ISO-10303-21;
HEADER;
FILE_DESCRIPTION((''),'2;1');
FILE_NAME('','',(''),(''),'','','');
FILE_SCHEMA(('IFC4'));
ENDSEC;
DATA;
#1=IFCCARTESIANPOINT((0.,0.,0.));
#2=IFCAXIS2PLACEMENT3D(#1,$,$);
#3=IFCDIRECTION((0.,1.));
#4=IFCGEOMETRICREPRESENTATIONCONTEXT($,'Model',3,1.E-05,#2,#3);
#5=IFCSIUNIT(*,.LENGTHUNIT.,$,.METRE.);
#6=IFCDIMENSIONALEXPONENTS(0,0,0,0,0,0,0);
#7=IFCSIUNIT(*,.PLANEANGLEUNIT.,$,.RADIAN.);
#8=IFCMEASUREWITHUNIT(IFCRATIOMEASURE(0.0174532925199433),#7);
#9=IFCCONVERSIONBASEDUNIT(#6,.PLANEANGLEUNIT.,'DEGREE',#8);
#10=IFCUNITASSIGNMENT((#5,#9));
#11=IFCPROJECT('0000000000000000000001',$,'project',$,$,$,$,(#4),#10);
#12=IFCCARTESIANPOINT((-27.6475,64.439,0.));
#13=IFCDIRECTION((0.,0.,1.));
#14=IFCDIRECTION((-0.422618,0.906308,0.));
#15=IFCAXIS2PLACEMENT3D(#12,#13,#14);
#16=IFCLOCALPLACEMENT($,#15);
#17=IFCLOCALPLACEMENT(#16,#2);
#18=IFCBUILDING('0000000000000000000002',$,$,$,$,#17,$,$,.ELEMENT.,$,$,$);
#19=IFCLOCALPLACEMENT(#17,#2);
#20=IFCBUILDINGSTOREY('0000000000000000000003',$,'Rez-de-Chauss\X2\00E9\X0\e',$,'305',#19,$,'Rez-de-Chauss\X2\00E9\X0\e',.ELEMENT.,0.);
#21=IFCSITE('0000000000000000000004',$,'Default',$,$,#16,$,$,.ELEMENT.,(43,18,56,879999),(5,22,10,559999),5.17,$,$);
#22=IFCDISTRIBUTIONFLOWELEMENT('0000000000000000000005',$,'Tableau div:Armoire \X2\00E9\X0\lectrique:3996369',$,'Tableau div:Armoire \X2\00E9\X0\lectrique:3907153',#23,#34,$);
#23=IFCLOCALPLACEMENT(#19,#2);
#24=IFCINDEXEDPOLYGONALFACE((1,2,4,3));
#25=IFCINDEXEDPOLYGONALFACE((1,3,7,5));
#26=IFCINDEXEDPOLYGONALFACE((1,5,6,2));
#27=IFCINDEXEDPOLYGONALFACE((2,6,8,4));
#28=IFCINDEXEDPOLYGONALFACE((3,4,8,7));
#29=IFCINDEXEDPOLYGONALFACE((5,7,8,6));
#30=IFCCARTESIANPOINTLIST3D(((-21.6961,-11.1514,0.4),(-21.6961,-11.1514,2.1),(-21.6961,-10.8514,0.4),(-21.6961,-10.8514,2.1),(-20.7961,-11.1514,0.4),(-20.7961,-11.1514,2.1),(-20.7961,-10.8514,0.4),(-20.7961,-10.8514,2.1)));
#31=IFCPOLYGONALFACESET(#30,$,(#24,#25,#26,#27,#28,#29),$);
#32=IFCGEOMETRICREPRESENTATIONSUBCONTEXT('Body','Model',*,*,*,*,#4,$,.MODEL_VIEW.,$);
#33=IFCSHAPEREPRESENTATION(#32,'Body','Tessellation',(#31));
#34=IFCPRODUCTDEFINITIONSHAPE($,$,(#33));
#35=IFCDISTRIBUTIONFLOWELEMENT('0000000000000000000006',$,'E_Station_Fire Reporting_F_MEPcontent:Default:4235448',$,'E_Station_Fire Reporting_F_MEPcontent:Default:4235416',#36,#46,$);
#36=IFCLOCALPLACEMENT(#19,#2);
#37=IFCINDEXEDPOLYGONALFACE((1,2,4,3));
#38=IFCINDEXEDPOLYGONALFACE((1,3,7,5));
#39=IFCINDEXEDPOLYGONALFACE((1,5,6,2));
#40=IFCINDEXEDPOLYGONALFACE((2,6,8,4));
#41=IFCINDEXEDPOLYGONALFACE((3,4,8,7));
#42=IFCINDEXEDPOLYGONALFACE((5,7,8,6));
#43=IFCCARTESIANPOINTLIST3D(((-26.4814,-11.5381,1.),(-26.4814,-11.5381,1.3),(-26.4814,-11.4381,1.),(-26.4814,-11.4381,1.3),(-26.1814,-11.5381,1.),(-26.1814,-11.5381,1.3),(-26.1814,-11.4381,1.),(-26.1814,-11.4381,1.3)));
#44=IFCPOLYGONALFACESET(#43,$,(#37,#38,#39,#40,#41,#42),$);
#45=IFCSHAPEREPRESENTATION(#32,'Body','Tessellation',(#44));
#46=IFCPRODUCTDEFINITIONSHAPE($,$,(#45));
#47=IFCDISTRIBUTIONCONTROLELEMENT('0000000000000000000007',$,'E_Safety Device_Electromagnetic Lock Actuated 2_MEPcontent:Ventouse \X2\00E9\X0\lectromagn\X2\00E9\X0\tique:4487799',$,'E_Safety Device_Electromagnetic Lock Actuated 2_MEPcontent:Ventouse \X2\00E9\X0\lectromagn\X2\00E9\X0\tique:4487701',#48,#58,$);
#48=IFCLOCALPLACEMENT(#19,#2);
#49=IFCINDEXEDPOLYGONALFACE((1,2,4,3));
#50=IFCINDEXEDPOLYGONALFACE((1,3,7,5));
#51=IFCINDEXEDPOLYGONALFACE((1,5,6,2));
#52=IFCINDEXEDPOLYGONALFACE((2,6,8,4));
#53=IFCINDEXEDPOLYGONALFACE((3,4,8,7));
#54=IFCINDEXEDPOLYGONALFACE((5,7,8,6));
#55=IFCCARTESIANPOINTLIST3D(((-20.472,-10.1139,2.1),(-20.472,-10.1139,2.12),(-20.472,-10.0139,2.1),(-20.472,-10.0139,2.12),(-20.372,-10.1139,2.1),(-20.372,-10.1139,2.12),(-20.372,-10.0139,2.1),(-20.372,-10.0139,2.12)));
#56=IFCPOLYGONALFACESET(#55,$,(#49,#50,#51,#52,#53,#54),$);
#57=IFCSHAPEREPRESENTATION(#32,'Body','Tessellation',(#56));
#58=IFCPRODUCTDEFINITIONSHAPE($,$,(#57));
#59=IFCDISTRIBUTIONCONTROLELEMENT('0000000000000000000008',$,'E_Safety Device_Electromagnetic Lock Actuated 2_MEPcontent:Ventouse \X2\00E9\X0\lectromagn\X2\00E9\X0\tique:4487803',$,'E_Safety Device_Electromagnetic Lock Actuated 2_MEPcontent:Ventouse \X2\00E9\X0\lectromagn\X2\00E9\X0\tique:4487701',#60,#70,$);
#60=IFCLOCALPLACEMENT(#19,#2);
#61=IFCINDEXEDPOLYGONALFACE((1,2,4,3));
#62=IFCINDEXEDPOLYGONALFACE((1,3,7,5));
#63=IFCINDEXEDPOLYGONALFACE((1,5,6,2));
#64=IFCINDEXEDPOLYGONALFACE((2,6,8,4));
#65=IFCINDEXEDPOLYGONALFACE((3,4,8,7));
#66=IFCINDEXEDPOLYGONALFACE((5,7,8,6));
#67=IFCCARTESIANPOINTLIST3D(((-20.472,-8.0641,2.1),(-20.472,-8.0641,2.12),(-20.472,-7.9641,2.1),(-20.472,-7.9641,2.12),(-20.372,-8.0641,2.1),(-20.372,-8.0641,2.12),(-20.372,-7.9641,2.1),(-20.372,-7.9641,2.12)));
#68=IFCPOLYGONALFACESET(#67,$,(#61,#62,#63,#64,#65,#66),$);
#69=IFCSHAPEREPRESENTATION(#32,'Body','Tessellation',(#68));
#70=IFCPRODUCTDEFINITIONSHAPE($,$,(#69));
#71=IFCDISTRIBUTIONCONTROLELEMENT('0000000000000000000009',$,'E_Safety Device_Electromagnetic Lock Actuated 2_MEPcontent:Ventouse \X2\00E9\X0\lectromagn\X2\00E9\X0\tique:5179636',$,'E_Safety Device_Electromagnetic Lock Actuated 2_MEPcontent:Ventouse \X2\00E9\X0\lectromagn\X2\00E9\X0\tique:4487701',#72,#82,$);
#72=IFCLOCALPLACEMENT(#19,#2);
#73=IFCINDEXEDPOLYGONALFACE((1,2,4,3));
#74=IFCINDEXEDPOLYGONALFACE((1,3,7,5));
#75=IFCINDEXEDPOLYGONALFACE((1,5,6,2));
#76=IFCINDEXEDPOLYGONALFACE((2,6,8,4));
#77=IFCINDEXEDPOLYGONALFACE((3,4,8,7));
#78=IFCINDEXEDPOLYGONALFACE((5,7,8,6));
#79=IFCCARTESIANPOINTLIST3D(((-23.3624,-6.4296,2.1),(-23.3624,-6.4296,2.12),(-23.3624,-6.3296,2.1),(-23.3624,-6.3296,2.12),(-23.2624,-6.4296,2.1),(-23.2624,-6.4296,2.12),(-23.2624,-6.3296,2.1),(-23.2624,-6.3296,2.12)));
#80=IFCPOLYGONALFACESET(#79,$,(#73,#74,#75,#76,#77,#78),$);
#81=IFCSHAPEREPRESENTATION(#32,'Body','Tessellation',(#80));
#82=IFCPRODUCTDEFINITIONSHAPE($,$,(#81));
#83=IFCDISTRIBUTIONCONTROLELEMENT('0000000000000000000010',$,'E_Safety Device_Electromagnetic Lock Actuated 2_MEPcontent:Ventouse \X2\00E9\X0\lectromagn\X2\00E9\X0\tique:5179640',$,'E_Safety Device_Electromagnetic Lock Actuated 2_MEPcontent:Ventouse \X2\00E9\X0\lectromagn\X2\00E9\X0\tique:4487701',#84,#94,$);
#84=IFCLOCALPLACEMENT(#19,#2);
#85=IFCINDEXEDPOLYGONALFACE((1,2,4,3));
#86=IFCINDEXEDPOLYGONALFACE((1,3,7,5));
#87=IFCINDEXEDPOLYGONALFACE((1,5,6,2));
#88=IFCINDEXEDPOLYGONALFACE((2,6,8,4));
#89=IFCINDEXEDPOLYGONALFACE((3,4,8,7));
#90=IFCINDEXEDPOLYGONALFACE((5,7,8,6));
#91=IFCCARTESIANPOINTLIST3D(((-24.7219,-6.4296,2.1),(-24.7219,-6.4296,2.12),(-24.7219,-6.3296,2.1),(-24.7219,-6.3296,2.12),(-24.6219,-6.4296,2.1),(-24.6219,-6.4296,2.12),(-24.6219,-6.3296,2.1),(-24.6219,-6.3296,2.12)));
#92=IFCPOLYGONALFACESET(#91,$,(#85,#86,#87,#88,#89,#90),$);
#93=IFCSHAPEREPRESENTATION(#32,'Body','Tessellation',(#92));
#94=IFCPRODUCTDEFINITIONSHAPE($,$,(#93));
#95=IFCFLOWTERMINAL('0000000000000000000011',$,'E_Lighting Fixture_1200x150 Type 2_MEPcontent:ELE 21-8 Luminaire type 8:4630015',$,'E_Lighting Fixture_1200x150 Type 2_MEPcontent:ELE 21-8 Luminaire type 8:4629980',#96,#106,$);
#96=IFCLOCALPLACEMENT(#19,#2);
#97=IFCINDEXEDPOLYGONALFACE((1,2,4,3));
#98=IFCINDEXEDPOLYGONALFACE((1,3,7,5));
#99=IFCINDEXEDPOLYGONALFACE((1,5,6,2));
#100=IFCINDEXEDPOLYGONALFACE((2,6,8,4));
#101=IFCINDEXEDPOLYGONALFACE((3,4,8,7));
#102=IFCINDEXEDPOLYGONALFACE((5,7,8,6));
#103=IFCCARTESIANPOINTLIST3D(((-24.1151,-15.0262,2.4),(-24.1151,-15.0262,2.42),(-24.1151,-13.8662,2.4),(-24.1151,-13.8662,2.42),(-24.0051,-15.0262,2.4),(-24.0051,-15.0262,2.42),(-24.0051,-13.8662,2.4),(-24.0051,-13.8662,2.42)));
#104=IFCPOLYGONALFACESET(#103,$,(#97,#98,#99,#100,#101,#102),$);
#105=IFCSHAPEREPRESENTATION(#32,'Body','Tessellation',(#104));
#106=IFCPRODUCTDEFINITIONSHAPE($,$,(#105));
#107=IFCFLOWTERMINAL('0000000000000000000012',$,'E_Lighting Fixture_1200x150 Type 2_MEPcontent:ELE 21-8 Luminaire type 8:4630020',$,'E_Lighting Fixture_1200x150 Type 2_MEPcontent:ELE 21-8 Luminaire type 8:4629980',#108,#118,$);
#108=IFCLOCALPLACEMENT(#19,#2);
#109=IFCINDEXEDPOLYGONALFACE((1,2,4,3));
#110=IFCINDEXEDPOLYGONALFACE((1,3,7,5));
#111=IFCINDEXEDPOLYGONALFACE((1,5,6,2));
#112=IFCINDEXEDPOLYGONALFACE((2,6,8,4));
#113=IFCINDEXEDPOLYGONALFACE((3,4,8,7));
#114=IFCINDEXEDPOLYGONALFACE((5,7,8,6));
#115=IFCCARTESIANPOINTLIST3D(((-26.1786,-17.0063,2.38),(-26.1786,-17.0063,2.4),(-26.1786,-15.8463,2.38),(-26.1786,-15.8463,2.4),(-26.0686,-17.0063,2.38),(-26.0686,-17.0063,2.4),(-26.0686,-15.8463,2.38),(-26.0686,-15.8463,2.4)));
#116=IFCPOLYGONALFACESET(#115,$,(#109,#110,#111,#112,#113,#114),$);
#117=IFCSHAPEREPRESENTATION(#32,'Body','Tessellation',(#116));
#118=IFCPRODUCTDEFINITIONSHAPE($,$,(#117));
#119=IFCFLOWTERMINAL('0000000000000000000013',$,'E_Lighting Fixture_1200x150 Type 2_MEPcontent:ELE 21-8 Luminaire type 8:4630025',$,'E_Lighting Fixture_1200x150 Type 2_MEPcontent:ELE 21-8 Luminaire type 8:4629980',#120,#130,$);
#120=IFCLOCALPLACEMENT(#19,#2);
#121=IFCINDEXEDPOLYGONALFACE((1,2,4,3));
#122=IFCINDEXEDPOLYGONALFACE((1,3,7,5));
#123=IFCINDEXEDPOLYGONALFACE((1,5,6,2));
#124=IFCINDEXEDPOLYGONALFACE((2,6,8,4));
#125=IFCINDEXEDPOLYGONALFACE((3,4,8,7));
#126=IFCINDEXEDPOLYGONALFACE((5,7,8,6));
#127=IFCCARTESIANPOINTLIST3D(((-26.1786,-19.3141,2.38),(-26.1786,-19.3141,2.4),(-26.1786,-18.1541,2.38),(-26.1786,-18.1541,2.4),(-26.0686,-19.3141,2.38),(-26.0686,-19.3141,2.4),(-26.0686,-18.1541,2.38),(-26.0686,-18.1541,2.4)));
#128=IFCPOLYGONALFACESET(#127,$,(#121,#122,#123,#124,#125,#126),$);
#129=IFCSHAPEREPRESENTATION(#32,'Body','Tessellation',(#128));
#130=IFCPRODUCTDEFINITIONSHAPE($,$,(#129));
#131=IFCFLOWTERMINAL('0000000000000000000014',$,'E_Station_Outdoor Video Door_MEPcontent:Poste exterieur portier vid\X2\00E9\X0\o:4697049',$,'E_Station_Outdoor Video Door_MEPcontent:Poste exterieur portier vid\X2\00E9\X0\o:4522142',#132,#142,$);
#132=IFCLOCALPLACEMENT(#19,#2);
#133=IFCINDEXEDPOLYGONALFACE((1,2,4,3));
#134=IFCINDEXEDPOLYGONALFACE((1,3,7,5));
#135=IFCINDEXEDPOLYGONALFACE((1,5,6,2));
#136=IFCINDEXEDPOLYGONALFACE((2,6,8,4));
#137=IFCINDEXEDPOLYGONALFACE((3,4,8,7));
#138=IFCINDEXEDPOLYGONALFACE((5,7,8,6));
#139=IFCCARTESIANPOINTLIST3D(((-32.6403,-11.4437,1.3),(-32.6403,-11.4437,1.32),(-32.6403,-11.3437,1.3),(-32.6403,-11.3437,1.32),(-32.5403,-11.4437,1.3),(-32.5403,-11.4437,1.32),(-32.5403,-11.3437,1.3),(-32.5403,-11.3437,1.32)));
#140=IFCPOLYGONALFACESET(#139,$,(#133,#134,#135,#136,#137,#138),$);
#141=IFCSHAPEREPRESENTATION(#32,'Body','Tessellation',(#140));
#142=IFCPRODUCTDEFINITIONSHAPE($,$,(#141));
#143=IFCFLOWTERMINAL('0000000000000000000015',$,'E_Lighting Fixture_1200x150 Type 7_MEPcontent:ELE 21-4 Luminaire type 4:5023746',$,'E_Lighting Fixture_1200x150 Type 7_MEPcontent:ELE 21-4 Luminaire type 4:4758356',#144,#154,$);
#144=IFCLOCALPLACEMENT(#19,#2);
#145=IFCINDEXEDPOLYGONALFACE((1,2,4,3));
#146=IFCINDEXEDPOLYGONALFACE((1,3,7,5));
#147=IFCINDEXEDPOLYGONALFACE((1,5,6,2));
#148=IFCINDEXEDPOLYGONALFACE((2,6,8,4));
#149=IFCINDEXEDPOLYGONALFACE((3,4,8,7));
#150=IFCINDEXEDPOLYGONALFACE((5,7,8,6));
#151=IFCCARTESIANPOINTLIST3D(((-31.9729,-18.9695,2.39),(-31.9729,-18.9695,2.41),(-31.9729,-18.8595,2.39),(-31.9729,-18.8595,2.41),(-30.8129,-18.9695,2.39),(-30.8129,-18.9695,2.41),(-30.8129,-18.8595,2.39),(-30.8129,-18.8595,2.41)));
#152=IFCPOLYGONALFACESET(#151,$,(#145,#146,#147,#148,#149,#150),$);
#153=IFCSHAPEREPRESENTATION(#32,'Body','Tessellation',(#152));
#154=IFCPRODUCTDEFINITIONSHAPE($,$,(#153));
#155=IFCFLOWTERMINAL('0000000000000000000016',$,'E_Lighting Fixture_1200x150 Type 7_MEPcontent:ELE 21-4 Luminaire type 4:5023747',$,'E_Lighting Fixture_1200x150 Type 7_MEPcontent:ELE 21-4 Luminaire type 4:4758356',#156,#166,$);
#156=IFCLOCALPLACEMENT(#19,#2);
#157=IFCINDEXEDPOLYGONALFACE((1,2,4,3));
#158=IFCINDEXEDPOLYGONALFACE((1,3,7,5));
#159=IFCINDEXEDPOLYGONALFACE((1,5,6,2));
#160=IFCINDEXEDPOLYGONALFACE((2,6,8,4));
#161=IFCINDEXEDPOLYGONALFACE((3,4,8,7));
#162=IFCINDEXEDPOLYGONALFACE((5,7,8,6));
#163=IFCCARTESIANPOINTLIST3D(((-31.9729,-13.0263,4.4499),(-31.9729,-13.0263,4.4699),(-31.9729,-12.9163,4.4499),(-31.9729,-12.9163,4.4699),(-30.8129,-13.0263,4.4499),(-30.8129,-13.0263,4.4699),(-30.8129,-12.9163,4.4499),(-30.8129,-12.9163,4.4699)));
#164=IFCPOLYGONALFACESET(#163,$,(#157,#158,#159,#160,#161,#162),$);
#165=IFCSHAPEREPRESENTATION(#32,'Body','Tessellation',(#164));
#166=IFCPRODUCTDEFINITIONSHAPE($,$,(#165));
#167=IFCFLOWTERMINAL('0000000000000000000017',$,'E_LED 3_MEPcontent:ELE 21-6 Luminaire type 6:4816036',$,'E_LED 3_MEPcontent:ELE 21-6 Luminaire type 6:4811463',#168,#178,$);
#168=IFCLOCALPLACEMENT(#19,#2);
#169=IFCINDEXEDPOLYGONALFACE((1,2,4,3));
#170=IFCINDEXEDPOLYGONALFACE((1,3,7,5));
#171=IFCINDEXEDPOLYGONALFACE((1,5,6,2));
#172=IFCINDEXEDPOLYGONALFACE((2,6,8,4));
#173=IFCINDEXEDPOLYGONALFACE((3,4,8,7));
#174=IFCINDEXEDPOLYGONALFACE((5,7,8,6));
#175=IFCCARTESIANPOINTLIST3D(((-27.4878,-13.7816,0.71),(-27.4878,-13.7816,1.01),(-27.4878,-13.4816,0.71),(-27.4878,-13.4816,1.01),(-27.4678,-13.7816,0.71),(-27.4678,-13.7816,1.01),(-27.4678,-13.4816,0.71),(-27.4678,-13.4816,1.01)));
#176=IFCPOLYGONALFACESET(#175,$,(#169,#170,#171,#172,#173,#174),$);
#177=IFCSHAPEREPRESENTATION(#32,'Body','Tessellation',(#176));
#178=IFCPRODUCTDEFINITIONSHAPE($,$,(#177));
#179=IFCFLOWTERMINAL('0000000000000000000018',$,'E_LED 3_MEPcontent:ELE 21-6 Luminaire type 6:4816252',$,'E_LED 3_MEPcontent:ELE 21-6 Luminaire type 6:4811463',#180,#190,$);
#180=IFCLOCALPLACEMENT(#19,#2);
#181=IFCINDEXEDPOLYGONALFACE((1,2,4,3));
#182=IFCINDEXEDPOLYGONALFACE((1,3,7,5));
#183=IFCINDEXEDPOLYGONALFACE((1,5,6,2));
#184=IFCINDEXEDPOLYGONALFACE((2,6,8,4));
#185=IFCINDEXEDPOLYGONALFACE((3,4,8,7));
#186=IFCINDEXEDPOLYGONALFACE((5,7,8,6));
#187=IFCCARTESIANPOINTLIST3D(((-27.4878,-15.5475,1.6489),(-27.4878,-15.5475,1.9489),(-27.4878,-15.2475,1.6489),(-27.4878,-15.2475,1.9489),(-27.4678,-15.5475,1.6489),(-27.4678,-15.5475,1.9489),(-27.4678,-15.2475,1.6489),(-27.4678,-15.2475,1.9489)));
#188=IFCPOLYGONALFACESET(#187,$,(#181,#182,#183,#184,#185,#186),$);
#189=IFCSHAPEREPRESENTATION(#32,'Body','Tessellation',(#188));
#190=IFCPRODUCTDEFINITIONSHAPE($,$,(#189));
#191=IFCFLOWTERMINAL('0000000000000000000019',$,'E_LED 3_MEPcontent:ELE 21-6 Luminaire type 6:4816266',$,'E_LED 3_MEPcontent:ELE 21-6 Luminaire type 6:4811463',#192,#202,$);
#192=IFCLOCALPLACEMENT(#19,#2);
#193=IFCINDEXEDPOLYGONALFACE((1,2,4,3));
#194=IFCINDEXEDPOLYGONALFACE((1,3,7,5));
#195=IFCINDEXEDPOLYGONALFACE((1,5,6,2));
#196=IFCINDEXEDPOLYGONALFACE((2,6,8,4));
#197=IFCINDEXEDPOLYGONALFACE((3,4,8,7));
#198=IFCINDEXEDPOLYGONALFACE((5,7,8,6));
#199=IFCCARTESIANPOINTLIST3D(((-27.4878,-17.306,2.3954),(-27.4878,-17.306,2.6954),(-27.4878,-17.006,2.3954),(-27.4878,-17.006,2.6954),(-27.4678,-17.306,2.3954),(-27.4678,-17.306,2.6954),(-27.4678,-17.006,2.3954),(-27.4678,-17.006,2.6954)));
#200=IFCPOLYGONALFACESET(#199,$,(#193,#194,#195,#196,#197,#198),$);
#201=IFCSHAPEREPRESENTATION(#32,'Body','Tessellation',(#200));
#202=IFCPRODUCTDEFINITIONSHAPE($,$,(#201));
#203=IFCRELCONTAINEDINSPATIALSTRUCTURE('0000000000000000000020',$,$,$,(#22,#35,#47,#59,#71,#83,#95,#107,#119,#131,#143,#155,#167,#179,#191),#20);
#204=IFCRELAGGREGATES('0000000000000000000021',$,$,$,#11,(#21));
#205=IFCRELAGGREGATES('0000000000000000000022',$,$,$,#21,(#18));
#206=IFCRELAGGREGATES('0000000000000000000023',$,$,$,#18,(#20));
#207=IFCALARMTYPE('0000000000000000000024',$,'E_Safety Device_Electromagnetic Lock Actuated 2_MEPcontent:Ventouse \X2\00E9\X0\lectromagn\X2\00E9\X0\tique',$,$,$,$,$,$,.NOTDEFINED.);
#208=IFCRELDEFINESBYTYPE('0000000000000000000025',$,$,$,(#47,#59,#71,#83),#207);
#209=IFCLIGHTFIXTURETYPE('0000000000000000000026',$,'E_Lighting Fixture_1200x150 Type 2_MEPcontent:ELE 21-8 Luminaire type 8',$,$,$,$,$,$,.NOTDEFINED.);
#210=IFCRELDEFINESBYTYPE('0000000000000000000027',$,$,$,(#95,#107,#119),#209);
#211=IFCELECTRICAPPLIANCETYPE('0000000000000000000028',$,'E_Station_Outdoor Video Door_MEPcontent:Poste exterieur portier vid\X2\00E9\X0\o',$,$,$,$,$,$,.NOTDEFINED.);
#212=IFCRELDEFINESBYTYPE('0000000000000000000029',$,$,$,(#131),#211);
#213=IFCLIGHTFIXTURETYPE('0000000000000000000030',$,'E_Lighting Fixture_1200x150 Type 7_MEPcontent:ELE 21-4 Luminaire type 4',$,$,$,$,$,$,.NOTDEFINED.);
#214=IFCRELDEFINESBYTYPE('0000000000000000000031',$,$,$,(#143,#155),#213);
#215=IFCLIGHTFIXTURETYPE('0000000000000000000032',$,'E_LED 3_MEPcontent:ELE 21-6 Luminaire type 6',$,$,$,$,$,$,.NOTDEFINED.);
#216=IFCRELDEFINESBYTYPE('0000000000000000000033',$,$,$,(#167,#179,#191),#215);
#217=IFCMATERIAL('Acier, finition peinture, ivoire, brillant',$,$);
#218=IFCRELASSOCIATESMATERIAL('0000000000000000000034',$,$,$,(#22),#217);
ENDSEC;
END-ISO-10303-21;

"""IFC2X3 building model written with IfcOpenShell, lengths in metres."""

from ifc_helpers import new_model, entity, si_unit, converted_unit, direction, frame, origin, origin_2d_with_axis, place, context, subcontext, project, spatial, rectangle, extrude, source, transform, mapped, material, type_object, type_shapes, element, save


model = new_model("IFC2X3")

# Units and contexts
model_context = context("Model", 3, precision=1e-05, world=origin(), true_north=direction((0.0, 1.0)))
body_context = subcontext(model_context, "Body", "Model", "MODEL_VIEW")
ifc_project = project(units=[si_unit("LENGTHUNIT", "METRE"), converted_unit("PLANEANGLEUNIT", "DEGREE", entity("IfcRatioMeasure", 0.0174532925199433), si_unit("PLANEANGLEUNIT", "RADIAN"), dimensions=[0, 0, 0, 0, 0, 0, 0])], contexts=[model_context])

# Site, building, storey
site_placement = place(None, frame((-27.6475, 64.439, 0.0), z_axis=(0.0, 0.0, 1.0), x_axis=(-0.422618, 0.906308, 0.0)))
site = spatial("IfcSite", under=ifc_project, at=site_placement, Name="Default", CompositionType="ELEMENT", RefLatitude=(43, 18, 56, 879999), RefLongitude=(5, 22, 10, 559999), RefElevation=5.17)
building_placement = place(site_placement, origin())
building = spatial("IfcBuilding", under=site, at=building_placement, CompositionType="ELEMENT")
storey_placement = place(building_placement, origin())
storey = spatial("IfcBuildingStorey", under=building, at=storey_placement, Name="Rez-de-Chaussée", ObjectType="305", LongName="Rez-de-Chaussée", CompositionType="ELEMENT", Elevation=0.0)

# Distribution flow elements
ifc_material_1 = material(Name="Acier, finition peinture, ivoire, brillant")
shared_shape_1 = source(origin(), body_context, "Body", "SweptSolid", [
    extrude(rectangle(XDim=0.9, YDim=0.3, at=origin_2d_with_axis()), frame((0.0, -0.45, 0.0), z_axis=(0.0, 0.0, 1.0), x_axis=(0.0, 1.0, 0.0)), (0.0, 0.0, 1.0), 1.7),
])
distribution_flow_element_1_placement = place(storey_placement, frame((-20.7961, -11.0014, 0.4), z_axis=(0.0, 0.0, 1.0), x_axis=(0.0, -1.0, 0.0)))
element("IfcDistributionFlowElement", 1, at=distribution_flow_element_1_placement, inside=storey, material=ifc_material_1, Name="Tableau div:Armoire électrique:3996369", ObjectType="Tableau div:Armoire électrique:3907153", context=body_context, shape_type="MappedRepresentation", body=[
    mapped(shared_shape_1, transform((0.0, 0.0, 0.0), scale=1.0)),
])
shared_shape_2 = source(origin(), body_context, "Body", "SweptSolid", [
    extrude(rectangle(XDim=0.3, YDim=0.3, at=origin_2d_with_axis()), frame((0.0, -0.15, 0.0), z_axis=(0.0, 0.0, 1.0), x_axis=(0.0, 1.0, 0.0)), (0.0, 0.0, 1.0), 0.1),
])
distribution_flow_element_2_placement = place(storey_placement, frame((-26.3314, -11.4381, 1.3), z_axis=(0.0, -1.0, 0.0), x_axis=(1.0, 0.0, 0.0)))
element("IfcDistributionFlowElement", 2, at=distribution_flow_element_2_placement, inside=storey, Name="E_Station_Fire Reporting_F_MEPcontent:Default:4235448", ObjectType="E_Station_Fire Reporting_F_MEPcontent:Default:4235416", context=body_context, shape_type="MappedRepresentation", body=[
    mapped(shared_shape_2, transform((0.0, 0.0, 0.0), scale=1.0)),
])

# Distribution control elements
alarm_type_1 = type_object("IfcAlarmType", Name="E_Safety Device_Electromagnetic Lock Actuated 2_MEPcontent:Ventouse électromagnétique", PredefinedType="NOTDEFINED")
shared_shape_3 = source(origin(), body_context, "Body", "SweptSolid", [
    extrude(rectangle(XDim=0.1, YDim=0.1, at=origin_2d_with_axis()), frame((0.0, 0.0, 0.0), z_axis=(0.0, 0.0, 1.0), x_axis=(0.0, -1.0, 0.0)), (0.0, 0.0, 1.0), 0.02),
])
type_shapes(alarm_type_1, [shared_shape_3])
distribution_control_element_1_placement = place(storey_placement, frame((-20.422, -10.0639, 2.1)))
element("IfcDistributionControlElement", 3, at=distribution_control_element_1_placement, inside=storey, type_object=alarm_type_1, Name="E_Safety Device_Electromagnetic Lock Actuated 2_MEPcontent:Ventouse électromagnétique:4487799", ObjectType="E_Safety Device_Electromagnetic Lock Actuated 2_MEPcontent:Ventouse électromagnétique:4487701", context=body_context, shape_type="MappedRepresentation", body=[
    mapped(shared_shape_3, transform((0.0, 0.0, 0.0), scale=1.0)),
])
for number, where, z_axis, x_axis, name in (
    (4, (-20.422, -8.0141, 2.1), (0.0, 0.0, 1.0), (-1.0, 0.0, 0.0), "E_Safety Device_Electromagnetic Lock Actuated 2_MEPcontent:Ventouse électromagnétique:4487803"),
    (5, (-23.3124, -6.3796, 2.1), (0.0, 0.0, 1.0), (0.0, 1.0, 0.0), "E_Safety Device_Electromagnetic Lock Actuated 2_MEPcontent:Ventouse électromagnétique:5179636"),
    (6, (-24.6719, -6.3796, 2.1), (0.0, 0.0, 1.0), (0.0, -1.0, 0.0), "E_Safety Device_Electromagnetic Lock Actuated 2_MEPcontent:Ventouse électromagnétique:5179640"),
):
    element("IfcDistributionControlElement", number, at=place(storey_placement, frame(where, z_axis=z_axis, x_axis=x_axis)), inside=storey, type_object=alarm_type_1, Name=name, ObjectType="E_Safety Device_Electromagnetic Lock Actuated 2_MEPcontent:Ventouse électromagnétique:4487701", context=body_context, shape_type="MappedRepresentation", body=[
        mapped(shared_shape_3, transform((0.0, 0.0, 0.0), scale=1.0)),
    ])

# Flow terminals
light_fixture_type_1 = type_object("IfcLightFixtureType", Name="E_Lighting Fixture_1200x150 Type 2_MEPcontent:ELE 21-8 Luminaire type 8", PredefinedType="NOTDEFINED")
shared_shape_4 = source(origin(), body_context, "Body", "SweptSolid", [
    extrude(rectangle(XDim=0.11, YDim=1.16, at=origin_2d_with_axis()), frame((0.0, 0.0, 0.0), z_axis=(0.0, 0.0, 1.0), x_axis=(0.0, -1.0, 0.0)), (0.0, 0.0, 1.0), 0.02),
])
type_shapes(light_fixture_type_1, [shared_shape_4])
for number, where, z_axis, x_axis, name in (
    (7, (-24.0601, -14.4462, 2.4), (0.0, 0.0, 1.0), (0.0, -1.0, 0.0), "E_Lighting Fixture_1200x150 Type 2_MEPcontent:ELE 21-8 Luminaire type 8:4630015"),
    (8, (-26.1236, -16.4263, 2.38), (0.0, 0.0, 1.0), (0.0, -1.0, 0.0), "E_Lighting Fixture_1200x150 Type 2_MEPcontent:ELE 21-8 Luminaire type 8:4630020"),
    (9, (-26.1236, -18.7341, 2.38), (0.0, 0.0, 1.0), (0.0, -1.0, 0.0), "E_Lighting Fixture_1200x150 Type 2_MEPcontent:ELE 21-8 Luminaire type 8:4630025"),
):
    element("IfcFlowTerminal", number, at=place(storey_placement, frame(where, z_axis=z_axis, x_axis=x_axis)), inside=storey, type_object=light_fixture_type_1, Name=name, ObjectType="E_Lighting Fixture_1200x150 Type 2_MEPcontent:ELE 21-8 Luminaire type 8:4629980", context=body_context, shape_type="MappedRepresentation", body=[
        mapped(shared_shape_4, transform((0.0, 0.0, 0.0), scale=1.0)),
    ])
electric_appliance_type_1 = type_object("IfcElectricApplianceType", Name="E_Station_Outdoor Video Door_MEPcontent:Poste exterieur portier vidéo", PredefinedType="NOTDEFINED")
shared_shape_5 = source(origin(), body_context, "Body", "SweptSolid", [
    extrude(rectangle(XDim=0.1, YDim=0.1, at=origin_2d_with_axis()), frame((0.0, 0.0, 0.0), z_axis=(0.0, 0.0, 1.0), x_axis=(0.0, -1.0, 0.0)), (0.0, 0.0, 1.0), 0.02),
])
type_shapes(electric_appliance_type_1, [shared_shape_5])
flow_terminal_1_placement = place(storey_placement, frame((-32.5903, -11.3937, 1.3)))
element("IfcFlowTerminal", 10, at=flow_terminal_1_placement, inside=storey, type_object=electric_appliance_type_1, Name="E_Station_Outdoor Video Door_MEPcontent:Poste exterieur portier vidéo:4697049", ObjectType="E_Station_Outdoor Video Door_MEPcontent:Poste exterieur portier vidéo:4522142", context=body_context, shape_type="MappedRepresentation", body=[
    mapped(shared_shape_5, transform((0.0, 0.0, 0.0), scale=1.0)),
])
light_fixture_type_2 = type_object("IfcLightFixtureType", Name="E_Lighting Fixture_1200x150 Type 7_MEPcontent:ELE 21-4 Luminaire type 4", PredefinedType="NOTDEFINED")
shared_shape_6 = source(origin(), body_context, "Body", "SweptSolid", [
    extrude(rectangle(XDim=0.11, YDim=1.16, at=origin_2d_with_axis()), frame((0.0, 0.0, 0.0), z_axis=(0.0, 0.0, 1.0), x_axis=(0.0, -1.0, 0.0)), (0.0, 0.0, 1.0), 0.02),
])
type_shapes(light_fixture_type_2, [shared_shape_6])
flow_terminal_2_placement = place(storey_placement, frame((-31.3929, -18.9145, 2.39), z_axis=(0.0, 0.0, 1.0), x_axis=(-1.0, 0.0, 0.0)))
element("IfcFlowTerminal", 11, at=flow_terminal_2_placement, inside=storey, type_object=light_fixture_type_2, Name="E_Lighting Fixture_1200x150 Type 7_MEPcontent:ELE 21-4 Luminaire type 4:5023746", ObjectType="E_Lighting Fixture_1200x150 Type 7_MEPcontent:ELE 21-4 Luminaire type 4:4758356", context=body_context, shape_type="MappedRepresentation", body=[
    mapped(shared_shape_6, transform((0.0, 0.0, 0.0), scale=1.0)),
])
flow_terminal_3_placement = place(storey_placement, frame((-31.3929, -12.9713, 4.4499)))
element("IfcFlowTerminal", 12, at=flow_terminal_3_placement, inside=storey, type_object=light_fixture_type_2, Name="E_Lighting Fixture_1200x150 Type 7_MEPcontent:ELE 21-4 Luminaire type 4:5023747", ObjectType="E_Lighting Fixture_1200x150 Type 7_MEPcontent:ELE 21-4 Luminaire type 4:4758356", context=body_context, shape_type="MappedRepresentation", body=[
    mapped(shared_shape_6, transform((0.0, 0.0, 0.0), scale=1.0)),
])
light_fixture_type_3 = type_object("IfcLightFixtureType", Name="E_LED 3_MEPcontent:ELE 21-6 Luminaire type 6", PredefinedType="NOTDEFINED")
shared_shape_7 = source(origin(), body_context, "Body", "SweptSolid", [
    extrude(rectangle(XDim=0.02, YDim=0.3, at=origin_2d_with_axis()), frame((0.0, 0.01, -0.15), z_axis=(0.0, 0.0, 1.0), x_axis=(0.0, -1.0, 0.0)), (0.0, 0.0, 1.0), 0.3),
])
type_shapes(light_fixture_type_3, [shared_shape_7])
for number, where, z_axis, x_axis, name in (
    (13, (-27.4878, -13.6316, 0.86), (0.0, 0.0, 1.0), (0.0, -1.0, 0.0), "E_LED 3_MEPcontent:ELE 21-6 Luminaire type 6:4816036"),
    (14, (-27.4878, -15.3975, 1.7989), (0.0, 0.0, 1.0), (0.0, -1.0, 0.0), "E_LED 3_MEPcontent:ELE 21-6 Luminaire type 6:4816252"),
    (15, (-27.4878, -17.156, 2.5454), (0.0, 0.0, 1.0), (0.0, -1.0, 0.0), "E_LED 3_MEPcontent:ELE 21-6 Luminaire type 6:4816266"),
):
    element("IfcFlowTerminal", number, at=place(storey_placement, frame(where, z_axis=z_axis, x_axis=x_axis)), inside=storey, type_object=light_fixture_type_3, Name=name, ObjectType="E_LED 3_MEPcontent:ELE 21-6 Luminaire type 6:4811463", context=body_context, shape_type="MappedRepresentation", body=[
        mapped(shared_shape_7, transform((0.0, 0.0, 0.0), scale=1.0)),
    ])

save(model, "model.ifc")
